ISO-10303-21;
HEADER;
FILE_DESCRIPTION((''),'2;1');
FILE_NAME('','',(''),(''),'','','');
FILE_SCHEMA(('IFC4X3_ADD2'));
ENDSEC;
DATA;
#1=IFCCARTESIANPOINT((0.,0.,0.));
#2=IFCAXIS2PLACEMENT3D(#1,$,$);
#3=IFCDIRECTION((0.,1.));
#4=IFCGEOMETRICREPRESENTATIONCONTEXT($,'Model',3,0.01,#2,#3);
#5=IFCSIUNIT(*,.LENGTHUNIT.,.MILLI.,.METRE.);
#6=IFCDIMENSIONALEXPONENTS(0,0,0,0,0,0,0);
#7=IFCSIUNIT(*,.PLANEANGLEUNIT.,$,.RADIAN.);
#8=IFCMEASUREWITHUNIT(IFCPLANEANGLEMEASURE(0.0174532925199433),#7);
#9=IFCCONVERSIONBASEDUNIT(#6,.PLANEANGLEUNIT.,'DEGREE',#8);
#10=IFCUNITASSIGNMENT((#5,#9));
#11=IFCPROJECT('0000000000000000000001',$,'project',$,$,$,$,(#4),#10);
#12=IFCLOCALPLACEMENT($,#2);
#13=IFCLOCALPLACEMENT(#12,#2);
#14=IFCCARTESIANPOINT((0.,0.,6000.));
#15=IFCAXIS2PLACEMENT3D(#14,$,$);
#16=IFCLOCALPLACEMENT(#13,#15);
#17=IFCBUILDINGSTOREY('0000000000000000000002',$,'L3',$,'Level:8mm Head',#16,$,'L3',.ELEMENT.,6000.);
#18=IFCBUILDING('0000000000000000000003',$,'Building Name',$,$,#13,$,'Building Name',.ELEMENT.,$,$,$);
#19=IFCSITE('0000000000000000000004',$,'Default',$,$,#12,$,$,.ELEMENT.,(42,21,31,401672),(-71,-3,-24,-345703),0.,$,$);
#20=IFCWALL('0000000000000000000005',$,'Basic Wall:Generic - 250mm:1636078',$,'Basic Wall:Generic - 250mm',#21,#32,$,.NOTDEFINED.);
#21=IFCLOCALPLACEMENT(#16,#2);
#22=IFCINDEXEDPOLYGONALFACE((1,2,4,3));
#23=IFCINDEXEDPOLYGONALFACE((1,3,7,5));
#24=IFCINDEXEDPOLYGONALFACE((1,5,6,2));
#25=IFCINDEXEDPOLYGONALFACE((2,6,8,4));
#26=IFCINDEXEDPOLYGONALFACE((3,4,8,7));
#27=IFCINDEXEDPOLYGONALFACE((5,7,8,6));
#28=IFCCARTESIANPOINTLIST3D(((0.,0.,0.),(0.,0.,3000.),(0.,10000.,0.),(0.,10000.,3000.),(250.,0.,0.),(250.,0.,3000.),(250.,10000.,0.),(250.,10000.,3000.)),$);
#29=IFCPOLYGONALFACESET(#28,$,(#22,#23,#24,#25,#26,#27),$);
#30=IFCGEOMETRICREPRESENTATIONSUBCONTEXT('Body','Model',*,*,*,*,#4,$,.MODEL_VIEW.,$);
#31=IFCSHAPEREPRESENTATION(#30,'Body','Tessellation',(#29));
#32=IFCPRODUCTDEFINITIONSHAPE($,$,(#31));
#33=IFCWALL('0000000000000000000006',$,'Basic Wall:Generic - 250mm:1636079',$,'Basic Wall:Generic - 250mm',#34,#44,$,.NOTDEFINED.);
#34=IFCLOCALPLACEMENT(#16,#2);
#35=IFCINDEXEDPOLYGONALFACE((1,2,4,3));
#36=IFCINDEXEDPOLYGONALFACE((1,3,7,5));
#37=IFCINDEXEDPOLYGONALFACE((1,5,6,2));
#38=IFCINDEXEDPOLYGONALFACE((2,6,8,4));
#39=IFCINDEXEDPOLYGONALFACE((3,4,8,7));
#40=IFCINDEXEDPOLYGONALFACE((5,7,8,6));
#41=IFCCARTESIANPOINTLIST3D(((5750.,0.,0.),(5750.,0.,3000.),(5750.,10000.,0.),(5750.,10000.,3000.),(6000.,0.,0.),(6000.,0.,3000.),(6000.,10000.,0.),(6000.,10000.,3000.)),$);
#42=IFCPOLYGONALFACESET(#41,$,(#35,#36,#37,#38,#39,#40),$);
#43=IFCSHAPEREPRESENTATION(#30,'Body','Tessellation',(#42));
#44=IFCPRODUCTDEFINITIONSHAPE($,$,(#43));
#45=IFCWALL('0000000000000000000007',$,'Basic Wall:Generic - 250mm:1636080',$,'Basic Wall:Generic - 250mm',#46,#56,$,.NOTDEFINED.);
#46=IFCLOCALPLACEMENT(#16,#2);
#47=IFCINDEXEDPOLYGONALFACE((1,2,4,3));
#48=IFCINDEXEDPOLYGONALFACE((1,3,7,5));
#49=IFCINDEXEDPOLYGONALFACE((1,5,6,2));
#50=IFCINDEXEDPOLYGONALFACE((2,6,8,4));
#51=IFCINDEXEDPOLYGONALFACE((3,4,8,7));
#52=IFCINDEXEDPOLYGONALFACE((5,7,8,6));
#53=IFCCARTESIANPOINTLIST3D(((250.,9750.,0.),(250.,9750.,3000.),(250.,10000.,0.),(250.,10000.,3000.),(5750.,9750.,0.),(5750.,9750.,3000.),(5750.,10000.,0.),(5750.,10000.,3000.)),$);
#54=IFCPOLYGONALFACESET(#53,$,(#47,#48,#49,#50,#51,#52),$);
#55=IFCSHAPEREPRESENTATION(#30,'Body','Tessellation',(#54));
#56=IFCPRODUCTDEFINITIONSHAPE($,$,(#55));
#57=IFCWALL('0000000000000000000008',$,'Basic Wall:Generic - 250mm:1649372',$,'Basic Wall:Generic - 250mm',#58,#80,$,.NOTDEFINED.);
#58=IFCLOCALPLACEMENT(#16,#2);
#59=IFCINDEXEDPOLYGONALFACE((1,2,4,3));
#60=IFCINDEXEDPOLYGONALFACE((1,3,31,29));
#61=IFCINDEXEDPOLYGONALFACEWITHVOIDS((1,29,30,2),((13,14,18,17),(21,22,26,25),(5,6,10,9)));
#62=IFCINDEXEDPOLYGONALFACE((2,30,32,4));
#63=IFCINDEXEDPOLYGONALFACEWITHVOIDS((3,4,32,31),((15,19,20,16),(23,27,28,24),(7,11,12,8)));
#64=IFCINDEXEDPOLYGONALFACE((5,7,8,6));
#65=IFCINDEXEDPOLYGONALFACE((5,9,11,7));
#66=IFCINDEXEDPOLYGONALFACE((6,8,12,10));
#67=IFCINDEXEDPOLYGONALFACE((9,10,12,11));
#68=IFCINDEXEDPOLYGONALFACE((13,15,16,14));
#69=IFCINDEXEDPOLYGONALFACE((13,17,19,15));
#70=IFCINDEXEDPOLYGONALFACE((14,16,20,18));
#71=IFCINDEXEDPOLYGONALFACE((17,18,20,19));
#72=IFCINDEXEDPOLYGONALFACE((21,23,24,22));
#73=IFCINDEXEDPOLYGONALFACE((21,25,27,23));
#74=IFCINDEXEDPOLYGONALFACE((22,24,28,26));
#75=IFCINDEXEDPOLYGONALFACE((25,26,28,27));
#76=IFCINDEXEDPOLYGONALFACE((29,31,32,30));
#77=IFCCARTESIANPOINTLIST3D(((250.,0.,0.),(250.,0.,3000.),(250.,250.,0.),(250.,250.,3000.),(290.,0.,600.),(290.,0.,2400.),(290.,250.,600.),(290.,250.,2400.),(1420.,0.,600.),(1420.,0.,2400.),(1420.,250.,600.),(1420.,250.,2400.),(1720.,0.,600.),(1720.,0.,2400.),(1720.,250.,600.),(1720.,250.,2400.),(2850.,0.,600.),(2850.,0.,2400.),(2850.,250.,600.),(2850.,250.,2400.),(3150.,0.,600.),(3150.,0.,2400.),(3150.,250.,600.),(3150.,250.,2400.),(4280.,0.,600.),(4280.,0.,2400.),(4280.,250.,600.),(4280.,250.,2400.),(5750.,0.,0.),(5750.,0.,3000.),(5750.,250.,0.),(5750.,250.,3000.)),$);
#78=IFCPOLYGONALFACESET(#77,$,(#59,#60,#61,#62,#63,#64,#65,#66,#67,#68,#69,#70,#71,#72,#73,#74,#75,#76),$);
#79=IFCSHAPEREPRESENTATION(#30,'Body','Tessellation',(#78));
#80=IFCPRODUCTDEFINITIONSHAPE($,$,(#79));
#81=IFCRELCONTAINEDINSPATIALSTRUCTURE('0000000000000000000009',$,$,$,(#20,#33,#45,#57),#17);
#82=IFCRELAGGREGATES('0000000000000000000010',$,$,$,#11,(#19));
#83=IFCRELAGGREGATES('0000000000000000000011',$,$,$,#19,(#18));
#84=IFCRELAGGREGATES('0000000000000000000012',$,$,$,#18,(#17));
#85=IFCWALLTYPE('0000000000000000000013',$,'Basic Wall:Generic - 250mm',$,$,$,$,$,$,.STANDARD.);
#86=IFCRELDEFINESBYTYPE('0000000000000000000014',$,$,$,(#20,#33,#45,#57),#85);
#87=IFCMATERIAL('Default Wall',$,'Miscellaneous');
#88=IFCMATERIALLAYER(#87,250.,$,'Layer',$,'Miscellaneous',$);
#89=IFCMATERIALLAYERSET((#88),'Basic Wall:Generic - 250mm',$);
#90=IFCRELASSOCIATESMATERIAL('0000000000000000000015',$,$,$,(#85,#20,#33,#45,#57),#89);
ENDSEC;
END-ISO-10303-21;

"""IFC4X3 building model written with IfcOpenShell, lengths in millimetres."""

from ifc_helpers import new_model, entity, si_unit, converted_unit, direction, frame, frame_2d, origin, place, context, subcontext, project, spatial, rectangle, extrude, material, layer, layer_set, type_object, element, save


model = new_model("IFC4X3")

# Units and contexts
model_context = context("Model", 3, precision=0.01, world=origin(), true_north=direction((0.0, 1.0)))
body_context = subcontext(model_context, "Body", "Model", "MODEL_VIEW")
ifc_project = project(units=[si_unit("LENGTHUNIT", "METRE", prefix="MILLI"), converted_unit("PLANEANGLEUNIT", "DEGREE", entity("IfcPlaneAngleMeasure", 0.0174532925199433), si_unit("PLANEANGLEUNIT", "RADIAN"), dimensions=[0, 0, 0, 0, 0, 0, 0])], contexts=[model_context])

# Site, building, storey
site_placement = place(None, origin())
site = spatial("IfcSite", under=ifc_project, at=site_placement, Name="Default", CompositionType="ELEMENT", RefLatitude=(42, 21, 31, 401672), RefLongitude=(-71, -3, -24, -345703), RefElevation=0.0)
building_placement = place(site_placement, origin())
building = spatial("IfcBuilding", under=site, at=building_placement, Name="Building Name", LongName="Building Name", CompositionType="ELEMENT")
storey_placement = place(building_placement, frame((0.0, 0.0, 6000.0)))
storey = spatial("IfcBuildingStorey", under=building, at=storey_placement, Name="L3", ObjectType="Level:8mm Head", LongName="L3", CompositionType="ELEMENT", Elevation=6000.0)

# Walls
ifc_material = material(Name="Default Wall", Category="Miscellaneous")
ifc_layer = layer(ifc_material, 250.0, Name="Layer", Category="Miscellaneous")
ifc_layer_set = layer_set([ifc_layer], Name="Basic Wall:Generic - 250mm")
wall_type = type_object("IfcWallType", Name="Basic Wall:Generic - 250mm", PredefinedType="STANDARD", material=ifc_layer_set)
wall_1_placement = place(storey_placement, frame((125.0, 10000.0, 0.0), z_axis=(0.0, 0.0, 1.0), x_axis=(0.0, -1.0, 0.0)))
element("IfcWall", 1, at=wall_1_placement, inside=storey, type_object=wall_type, material=ifc_layer_set, Name="Basic Wall:Generic - 250mm:1636078", ObjectType="Basic Wall:Generic - 250mm", PredefinedType="NOTDEFINED", context=body_context, shape_type="SweptSolid", body=[
    extrude(rectangle(XDim=10000.0, YDim=250.0, at=frame_2d((5000.0, 0.0), x_axis=(-1.0, 0.0))), origin(), (0.0, 0.0, 1.0), 3000.0),
])
wall_2_placement = place(storey_placement, frame((5875.0, 0.0, 0.0), z_axis=(0.0, 0.0, 1.0), x_axis=(0.0, 1.0, 0.0)))
element("IfcWall", 2, at=wall_2_placement, inside=storey, type_object=wall_type, material=ifc_layer_set, Name="Basic Wall:Generic - 250mm:1636079", ObjectType="Basic Wall:Generic - 250mm", PredefinedType="NOTDEFINED", context=body_context, shape_type="SweptSolid", body=[
    extrude(rectangle(XDim=10000.0, YDim=250.0, at=frame_2d((5000.0, 0.0), x_axis=(-1.0, 0.0))), origin(), (0.0, 0.0, 1.0), 3000.0),
])
wall_3_placement = place(storey_placement, frame((5750.0, 9875.0, 0.0), z_axis=(0.0, 0.0, 1.0), x_axis=(-1.0, 0.0, 0.0)))
element("IfcWall", 3, at=wall_3_placement, inside=storey, type_object=wall_type, material=ifc_layer_set, Name="Basic Wall:Generic - 250mm:1636080", ObjectType="Basic Wall:Generic - 250mm", PredefinedType="NOTDEFINED", context=body_context, shape_type="SweptSolid", body=[
    extrude(rectangle(XDim=5500.0, YDim=250.0, at=frame_2d((2750.0, 0.0), x_axis=(-1.0, 0.0))), origin(), (0.0, 0.0, 1.0), 3000.0),
])

# Wall, openings
wall_4_placement = place(storey_placement, frame((250.0, 125.0, 0.0)))
wall_4 = element("IfcWall", 4, at=wall_4_placement, inside=storey, type_object=wall_type, material=ifc_layer_set, Name="Basic Wall:Generic - 250mm:1649372", ObjectType="Basic Wall:Generic - 250mm", PredefinedType="NOTDEFINED", context=body_context, shape_type="SweptSolid", body=[
    extrude(rectangle(XDim=5500.0, YDim=250.0, at=frame_2d((2750.0, 0.0), x_axis=(-1.0, 0.0))), origin(), (0.0, 0.0, 1.0), 3000.0),
])
opening_1_placement = place(wall_4_placement, frame((40.0, -125.0, 600.0)))
element("IfcOpeningElement", 5, at=opening_1_placement, cuts=wall_4, PredefinedType="OPENING", context=body_context, shape_type="SweptSolid", body=[
    extrude(rectangle(XDim=1800.0, YDim=1130.0, at=frame_2d((900.0, 565.0), x_axis=(-1.0, 0.0))), frame((0.0, 0.0, 0.0), z_axis=(0.0, 1.0, 0.0), x_axis=(0.0, 0.0, 1.0)), (0.0, 0.0, 1.0), 250.0),
])
opening_2_placement = place(wall_4_placement, frame((2900.0, -125.0, 600.0)))
element("IfcOpeningElement", 6, at=opening_2_placement, cuts=wall_4, PredefinedType="OPENING", context=body_context, shape_type="SweptSolid", body=[
    extrude(rectangle(XDim=1800.0, YDim=1130.0, at=frame_2d((900.0, 565.0), x_axis=(-1.0, 0.0))), frame((0.0, 0.0, 0.0), z_axis=(0.0, 1.0, 0.0), x_axis=(0.0, 0.0, 1.0)), (0.0, 0.0, 1.0), 250.0),
])
opening_3_placement = place(wall_4_placement, frame((1470.0, -125.0, 600.0)))
element("IfcOpeningElement", 7, at=opening_3_placement, cuts=wall_4, PredefinedType="OPENING", context=body_context, shape_type="SweptSolid", body=[
    extrude(rectangle(XDim=1800.0, YDim=1130.0, at=frame_2d((900.0, 565.0), x_axis=(-1.0, 0.0))), frame((0.0, 0.0, 0.0), z_axis=(0.0, 1.0, 0.0), x_axis=(0.0, 0.0, 1.0)), (0.0, 0.0, 1.0), 250.0),
])

save(model, "model.ifc")
